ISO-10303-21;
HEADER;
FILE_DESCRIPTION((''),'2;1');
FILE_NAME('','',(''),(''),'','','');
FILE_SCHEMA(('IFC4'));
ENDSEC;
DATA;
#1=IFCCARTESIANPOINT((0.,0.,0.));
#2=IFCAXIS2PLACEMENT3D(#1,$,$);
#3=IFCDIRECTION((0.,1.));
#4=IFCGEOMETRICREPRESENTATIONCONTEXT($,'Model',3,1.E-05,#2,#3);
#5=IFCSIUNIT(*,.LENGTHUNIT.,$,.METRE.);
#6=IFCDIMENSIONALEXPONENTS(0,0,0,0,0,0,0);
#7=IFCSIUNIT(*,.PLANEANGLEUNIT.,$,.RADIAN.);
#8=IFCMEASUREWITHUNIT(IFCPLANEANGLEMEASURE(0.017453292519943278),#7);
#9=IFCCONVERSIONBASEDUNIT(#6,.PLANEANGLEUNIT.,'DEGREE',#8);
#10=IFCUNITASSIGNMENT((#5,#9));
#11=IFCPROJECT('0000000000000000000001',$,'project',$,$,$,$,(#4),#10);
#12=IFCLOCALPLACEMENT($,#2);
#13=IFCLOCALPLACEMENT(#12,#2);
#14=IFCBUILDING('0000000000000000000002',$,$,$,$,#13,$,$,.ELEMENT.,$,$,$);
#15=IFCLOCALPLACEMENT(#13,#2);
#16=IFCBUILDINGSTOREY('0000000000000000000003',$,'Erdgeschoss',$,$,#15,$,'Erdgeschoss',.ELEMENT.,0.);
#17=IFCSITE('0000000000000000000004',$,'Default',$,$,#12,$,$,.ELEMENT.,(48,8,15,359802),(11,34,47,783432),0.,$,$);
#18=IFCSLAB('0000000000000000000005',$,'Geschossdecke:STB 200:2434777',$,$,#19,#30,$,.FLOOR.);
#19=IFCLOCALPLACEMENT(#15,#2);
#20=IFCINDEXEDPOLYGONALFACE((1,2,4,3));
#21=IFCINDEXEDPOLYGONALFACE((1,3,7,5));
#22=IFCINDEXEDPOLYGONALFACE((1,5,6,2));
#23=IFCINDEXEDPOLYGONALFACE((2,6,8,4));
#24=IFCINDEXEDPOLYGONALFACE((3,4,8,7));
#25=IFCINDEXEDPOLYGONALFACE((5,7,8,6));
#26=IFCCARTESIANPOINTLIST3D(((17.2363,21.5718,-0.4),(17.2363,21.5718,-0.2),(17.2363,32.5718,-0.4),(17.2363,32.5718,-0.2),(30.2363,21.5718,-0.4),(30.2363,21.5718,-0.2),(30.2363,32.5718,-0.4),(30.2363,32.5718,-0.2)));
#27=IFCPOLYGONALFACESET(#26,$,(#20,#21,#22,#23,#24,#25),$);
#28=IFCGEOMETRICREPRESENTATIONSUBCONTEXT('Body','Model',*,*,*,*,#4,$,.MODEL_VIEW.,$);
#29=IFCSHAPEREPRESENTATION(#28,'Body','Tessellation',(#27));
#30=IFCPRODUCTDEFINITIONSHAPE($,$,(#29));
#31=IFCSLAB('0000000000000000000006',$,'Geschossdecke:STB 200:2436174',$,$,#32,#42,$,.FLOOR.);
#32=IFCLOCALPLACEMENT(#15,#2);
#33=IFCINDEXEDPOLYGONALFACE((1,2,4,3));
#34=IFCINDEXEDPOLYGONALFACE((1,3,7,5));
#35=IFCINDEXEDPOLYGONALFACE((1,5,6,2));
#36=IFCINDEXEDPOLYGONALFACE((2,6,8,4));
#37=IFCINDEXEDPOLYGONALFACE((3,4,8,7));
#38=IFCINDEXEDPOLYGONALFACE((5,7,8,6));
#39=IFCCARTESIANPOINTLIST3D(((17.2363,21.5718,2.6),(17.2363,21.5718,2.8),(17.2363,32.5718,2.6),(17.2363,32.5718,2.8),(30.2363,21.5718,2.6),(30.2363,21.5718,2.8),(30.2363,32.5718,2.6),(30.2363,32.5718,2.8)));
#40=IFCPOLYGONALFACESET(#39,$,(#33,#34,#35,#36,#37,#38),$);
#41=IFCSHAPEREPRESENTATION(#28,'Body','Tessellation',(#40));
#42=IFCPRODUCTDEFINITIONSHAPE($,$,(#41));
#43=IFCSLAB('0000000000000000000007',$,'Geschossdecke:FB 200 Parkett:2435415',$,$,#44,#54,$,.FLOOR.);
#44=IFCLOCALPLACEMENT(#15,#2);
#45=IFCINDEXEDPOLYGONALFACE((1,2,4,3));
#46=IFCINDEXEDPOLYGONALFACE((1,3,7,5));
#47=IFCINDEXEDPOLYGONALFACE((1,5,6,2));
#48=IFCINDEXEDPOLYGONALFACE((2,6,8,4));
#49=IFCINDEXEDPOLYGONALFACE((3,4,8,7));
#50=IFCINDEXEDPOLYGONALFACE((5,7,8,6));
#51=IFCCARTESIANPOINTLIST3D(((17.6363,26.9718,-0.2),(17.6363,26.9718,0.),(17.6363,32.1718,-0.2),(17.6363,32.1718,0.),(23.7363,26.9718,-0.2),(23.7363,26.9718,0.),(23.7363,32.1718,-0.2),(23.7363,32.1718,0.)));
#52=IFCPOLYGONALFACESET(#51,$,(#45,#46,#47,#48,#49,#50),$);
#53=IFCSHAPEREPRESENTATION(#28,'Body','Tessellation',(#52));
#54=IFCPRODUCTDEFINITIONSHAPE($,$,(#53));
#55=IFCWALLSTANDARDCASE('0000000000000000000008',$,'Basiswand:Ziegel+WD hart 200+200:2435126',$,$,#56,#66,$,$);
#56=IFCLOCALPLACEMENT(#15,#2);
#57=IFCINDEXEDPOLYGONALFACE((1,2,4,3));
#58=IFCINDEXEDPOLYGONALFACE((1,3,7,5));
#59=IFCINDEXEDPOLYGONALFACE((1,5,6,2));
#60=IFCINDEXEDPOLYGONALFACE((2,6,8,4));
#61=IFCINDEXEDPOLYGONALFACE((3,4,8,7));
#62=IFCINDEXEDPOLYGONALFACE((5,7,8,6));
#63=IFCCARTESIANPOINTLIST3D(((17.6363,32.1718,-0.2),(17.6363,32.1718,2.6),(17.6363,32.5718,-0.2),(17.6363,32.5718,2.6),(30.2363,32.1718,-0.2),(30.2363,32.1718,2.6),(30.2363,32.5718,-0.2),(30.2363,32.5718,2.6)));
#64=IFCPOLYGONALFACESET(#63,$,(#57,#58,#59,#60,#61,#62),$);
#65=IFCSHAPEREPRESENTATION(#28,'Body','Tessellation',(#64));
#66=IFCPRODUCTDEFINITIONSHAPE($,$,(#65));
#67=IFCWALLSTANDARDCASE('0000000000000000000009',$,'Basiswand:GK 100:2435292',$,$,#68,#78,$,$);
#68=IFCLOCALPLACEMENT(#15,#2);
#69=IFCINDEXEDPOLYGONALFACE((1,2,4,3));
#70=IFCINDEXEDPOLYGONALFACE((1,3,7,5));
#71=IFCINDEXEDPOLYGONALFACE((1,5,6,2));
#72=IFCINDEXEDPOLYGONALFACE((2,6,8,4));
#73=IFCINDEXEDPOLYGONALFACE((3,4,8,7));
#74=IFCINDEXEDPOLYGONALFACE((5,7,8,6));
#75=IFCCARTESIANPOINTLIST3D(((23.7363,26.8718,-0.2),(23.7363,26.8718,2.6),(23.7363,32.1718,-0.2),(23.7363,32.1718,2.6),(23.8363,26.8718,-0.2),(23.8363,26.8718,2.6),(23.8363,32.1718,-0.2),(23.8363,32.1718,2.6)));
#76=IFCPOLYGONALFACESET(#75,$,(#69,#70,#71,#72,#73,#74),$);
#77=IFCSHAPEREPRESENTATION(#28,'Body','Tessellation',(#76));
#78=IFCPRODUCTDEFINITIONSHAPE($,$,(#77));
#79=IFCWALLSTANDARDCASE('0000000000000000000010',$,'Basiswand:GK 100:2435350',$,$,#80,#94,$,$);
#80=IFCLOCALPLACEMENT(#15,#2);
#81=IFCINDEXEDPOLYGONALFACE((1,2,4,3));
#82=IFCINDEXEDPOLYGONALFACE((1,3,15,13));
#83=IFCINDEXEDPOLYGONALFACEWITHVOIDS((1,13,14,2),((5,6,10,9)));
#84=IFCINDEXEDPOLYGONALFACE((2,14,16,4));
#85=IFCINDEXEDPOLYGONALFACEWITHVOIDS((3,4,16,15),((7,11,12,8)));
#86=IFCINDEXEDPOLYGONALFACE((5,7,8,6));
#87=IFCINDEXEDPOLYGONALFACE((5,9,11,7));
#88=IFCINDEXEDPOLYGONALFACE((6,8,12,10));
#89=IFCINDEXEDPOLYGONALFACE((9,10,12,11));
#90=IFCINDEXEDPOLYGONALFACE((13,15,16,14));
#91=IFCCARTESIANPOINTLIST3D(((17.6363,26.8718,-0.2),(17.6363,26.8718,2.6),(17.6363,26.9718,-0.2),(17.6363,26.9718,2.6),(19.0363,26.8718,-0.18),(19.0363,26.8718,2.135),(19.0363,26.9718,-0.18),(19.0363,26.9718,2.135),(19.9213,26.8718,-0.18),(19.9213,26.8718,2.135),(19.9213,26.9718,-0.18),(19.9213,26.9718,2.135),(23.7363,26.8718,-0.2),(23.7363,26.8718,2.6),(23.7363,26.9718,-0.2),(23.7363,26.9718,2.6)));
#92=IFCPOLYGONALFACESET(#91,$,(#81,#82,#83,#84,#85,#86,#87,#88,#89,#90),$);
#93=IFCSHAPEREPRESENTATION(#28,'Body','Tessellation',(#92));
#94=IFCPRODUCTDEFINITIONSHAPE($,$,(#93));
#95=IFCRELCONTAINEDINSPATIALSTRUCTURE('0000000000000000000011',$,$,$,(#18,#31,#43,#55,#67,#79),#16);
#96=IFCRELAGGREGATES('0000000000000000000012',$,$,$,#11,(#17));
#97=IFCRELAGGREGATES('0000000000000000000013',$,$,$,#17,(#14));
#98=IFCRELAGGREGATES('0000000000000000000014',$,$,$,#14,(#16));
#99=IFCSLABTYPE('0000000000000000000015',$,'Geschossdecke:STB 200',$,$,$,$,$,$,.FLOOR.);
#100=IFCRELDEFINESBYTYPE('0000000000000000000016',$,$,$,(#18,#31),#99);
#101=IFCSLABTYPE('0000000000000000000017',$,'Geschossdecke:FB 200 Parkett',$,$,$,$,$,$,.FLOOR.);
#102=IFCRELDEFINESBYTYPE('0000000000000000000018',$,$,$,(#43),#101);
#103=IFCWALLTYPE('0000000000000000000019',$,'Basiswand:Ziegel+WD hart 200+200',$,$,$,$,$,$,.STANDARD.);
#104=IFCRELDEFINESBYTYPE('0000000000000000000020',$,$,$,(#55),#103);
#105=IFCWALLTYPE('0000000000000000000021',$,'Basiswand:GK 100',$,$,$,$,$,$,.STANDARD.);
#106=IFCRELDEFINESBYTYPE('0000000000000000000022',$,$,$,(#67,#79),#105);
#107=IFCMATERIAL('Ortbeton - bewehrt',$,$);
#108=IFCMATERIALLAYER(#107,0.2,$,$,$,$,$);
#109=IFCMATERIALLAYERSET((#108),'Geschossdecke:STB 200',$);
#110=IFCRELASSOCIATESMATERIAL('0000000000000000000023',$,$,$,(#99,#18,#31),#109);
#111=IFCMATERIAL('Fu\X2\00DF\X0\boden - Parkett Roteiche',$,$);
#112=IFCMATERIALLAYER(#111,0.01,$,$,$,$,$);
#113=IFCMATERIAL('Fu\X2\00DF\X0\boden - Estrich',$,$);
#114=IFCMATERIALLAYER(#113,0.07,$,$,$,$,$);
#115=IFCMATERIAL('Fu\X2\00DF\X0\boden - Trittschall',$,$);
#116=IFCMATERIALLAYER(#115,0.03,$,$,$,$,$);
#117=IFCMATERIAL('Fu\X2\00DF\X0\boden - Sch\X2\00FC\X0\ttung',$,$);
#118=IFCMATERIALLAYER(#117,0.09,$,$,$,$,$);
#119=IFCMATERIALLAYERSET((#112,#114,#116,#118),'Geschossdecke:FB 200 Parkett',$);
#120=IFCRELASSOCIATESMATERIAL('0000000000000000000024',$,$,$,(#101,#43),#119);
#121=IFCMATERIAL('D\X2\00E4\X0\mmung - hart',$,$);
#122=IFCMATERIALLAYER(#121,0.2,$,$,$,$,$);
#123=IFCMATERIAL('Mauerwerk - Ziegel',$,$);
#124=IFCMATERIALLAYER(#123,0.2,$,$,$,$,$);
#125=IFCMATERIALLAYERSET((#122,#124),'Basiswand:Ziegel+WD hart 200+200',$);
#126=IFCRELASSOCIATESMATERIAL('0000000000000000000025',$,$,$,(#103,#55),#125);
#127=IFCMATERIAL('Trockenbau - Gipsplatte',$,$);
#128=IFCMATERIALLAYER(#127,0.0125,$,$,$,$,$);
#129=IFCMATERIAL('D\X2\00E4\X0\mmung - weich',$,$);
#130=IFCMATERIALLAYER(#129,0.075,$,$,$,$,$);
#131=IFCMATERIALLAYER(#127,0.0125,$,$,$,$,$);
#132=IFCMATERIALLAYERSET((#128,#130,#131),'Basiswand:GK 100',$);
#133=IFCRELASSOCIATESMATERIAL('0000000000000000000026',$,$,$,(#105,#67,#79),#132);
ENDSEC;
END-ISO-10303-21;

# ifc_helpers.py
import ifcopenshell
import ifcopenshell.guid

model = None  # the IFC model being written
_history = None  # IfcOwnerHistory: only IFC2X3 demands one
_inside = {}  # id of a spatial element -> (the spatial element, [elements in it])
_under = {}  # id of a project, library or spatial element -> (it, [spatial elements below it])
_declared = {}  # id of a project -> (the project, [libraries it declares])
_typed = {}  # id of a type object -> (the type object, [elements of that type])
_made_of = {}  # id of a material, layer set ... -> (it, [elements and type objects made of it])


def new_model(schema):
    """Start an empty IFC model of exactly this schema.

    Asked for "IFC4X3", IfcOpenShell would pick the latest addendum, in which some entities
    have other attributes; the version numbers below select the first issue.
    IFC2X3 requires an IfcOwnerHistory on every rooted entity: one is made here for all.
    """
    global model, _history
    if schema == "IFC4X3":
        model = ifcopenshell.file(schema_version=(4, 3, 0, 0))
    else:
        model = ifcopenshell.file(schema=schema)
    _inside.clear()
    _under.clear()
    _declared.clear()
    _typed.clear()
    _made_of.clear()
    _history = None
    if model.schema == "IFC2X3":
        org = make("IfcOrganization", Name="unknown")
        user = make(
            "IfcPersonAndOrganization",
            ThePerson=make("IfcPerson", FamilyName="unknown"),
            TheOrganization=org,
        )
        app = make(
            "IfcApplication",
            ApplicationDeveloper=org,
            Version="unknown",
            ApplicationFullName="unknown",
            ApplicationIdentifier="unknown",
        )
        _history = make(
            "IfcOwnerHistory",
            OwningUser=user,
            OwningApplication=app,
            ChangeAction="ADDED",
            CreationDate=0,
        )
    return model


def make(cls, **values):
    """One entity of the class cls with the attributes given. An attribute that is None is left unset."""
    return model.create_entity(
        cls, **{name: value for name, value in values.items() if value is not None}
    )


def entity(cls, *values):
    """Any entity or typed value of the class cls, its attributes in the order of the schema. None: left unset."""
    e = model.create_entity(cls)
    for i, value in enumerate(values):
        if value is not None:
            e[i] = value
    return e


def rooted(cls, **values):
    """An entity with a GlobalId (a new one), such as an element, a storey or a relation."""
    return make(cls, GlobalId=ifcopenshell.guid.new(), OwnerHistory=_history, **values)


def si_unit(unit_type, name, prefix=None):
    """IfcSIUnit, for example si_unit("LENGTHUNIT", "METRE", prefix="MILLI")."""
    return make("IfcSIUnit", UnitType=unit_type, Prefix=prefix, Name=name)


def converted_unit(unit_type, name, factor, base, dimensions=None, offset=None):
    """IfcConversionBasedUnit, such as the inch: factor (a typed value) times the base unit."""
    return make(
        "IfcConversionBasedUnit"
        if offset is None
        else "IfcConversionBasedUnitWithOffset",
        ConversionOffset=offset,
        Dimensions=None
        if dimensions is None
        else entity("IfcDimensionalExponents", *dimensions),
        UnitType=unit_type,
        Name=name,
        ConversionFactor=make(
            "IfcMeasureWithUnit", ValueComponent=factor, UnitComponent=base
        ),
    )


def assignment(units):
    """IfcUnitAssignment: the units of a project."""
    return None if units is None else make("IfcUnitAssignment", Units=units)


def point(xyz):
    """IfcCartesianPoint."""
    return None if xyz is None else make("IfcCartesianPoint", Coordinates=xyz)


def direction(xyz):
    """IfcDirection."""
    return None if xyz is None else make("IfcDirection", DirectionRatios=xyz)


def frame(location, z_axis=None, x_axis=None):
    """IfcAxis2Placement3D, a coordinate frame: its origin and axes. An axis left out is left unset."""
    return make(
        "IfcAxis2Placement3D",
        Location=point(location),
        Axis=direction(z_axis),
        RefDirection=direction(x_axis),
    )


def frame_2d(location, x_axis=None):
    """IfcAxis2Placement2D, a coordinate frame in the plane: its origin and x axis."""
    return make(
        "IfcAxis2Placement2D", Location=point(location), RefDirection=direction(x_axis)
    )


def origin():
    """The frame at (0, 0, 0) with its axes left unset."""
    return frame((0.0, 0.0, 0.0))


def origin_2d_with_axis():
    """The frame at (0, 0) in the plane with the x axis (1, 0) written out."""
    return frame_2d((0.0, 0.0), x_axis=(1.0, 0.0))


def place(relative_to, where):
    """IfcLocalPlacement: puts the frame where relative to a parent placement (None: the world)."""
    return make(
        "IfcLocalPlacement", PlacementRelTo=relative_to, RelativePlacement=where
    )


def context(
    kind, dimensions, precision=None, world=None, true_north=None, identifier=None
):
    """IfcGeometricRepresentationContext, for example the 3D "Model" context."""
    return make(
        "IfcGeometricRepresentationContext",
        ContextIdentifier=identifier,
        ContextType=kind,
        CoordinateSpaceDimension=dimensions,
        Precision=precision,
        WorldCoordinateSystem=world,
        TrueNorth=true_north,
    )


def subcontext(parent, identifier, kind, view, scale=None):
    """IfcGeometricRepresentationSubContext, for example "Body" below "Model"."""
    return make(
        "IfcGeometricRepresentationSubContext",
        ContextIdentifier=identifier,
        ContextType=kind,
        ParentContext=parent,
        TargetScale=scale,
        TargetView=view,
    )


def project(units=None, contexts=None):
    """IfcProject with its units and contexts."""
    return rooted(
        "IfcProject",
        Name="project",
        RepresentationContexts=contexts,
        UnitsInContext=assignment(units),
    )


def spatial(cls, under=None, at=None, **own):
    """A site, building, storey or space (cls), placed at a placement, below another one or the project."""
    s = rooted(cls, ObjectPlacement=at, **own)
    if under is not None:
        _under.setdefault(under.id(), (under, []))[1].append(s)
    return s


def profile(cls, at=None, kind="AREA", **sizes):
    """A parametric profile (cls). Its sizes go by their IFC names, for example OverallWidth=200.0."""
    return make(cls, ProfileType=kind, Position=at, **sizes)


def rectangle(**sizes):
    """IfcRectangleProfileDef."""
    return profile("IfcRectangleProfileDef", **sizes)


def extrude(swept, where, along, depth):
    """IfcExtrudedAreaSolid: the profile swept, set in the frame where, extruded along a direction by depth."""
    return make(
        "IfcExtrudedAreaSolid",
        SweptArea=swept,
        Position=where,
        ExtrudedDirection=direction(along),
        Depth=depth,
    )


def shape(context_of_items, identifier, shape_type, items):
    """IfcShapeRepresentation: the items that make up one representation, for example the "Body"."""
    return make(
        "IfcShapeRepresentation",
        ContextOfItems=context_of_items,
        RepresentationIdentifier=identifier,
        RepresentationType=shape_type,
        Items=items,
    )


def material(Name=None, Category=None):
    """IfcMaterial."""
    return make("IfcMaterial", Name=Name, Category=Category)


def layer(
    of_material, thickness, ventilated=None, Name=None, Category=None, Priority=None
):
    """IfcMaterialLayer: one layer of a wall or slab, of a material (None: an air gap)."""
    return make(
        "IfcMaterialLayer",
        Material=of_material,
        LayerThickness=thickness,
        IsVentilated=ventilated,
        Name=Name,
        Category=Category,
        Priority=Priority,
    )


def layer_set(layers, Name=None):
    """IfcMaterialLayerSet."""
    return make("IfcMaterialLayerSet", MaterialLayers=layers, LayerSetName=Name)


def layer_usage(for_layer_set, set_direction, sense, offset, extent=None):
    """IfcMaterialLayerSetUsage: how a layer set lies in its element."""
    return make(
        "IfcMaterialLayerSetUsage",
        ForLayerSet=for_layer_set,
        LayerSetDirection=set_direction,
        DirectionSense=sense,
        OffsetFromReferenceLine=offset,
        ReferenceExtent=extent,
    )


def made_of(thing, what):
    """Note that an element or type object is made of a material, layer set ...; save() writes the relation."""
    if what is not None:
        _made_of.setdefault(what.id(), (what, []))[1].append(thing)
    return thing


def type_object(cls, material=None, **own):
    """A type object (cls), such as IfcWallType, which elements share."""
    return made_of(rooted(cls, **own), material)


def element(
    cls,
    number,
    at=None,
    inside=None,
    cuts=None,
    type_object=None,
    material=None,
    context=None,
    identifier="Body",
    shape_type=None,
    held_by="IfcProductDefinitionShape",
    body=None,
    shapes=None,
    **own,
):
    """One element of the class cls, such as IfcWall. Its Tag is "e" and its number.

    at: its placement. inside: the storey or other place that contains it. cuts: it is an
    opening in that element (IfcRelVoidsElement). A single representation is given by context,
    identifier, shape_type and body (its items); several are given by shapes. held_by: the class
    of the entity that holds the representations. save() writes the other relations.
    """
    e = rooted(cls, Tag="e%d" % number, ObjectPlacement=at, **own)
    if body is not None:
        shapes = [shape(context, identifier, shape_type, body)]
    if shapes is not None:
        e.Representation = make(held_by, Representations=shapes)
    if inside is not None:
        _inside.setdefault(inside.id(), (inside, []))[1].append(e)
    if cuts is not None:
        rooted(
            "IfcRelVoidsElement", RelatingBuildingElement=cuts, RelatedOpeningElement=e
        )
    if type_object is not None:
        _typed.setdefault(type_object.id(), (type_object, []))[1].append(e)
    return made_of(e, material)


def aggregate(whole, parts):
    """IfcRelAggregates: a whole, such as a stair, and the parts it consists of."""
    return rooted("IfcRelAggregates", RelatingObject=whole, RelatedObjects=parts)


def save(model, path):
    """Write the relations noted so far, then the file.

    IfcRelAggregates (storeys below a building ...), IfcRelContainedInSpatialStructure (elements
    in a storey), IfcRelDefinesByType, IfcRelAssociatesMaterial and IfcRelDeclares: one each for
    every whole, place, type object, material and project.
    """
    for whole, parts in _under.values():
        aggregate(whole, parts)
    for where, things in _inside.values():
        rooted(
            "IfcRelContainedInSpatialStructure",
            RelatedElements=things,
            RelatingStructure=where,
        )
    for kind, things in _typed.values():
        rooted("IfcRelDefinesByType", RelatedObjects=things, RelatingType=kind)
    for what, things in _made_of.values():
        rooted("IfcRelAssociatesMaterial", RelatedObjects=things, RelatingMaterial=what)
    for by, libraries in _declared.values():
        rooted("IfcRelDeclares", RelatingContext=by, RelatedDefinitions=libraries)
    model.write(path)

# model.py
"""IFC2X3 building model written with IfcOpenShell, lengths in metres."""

from ifc_helpers import new_model, entity, si_unit, converted_unit, direction, frame, frame_2d, origin, origin_2d_with_axis, place, context, subcontext, project, spatial, rectangle, extrude, material, layer, layer_set, layer_usage, type_object, element, save


model = new_model("IFC2X3")

# Units and contexts
model_context = context("Model", 3, precision=1e-05, world=origin(), true_north=direction((0.0, 1.0)))
body_context = subcontext(model_context, "Body", "Model", "MODEL_VIEW")
ifc_project = project(units=[si_unit("LENGTHUNIT", "METRE"), converted_unit("PLANEANGLEUNIT", "DEGREE", entity("IfcPlaneAngleMeasure", 0.017453292519943278), si_unit("PLANEANGLEUNIT", "RADIAN"), dimensions=[0, 0, 0, 0, 0, 0, 0])], contexts=[model_context])

# Site, building, storey
site_placement = place(None, origin())
site = spatial("IfcSite", under=ifc_project, at=site_placement, Name="Default", CompositionType="ELEMENT", RefLatitude=(48, 8, 15, 359802), RefLongitude=(11, 34, 47, 783432), RefElevation=0.0)
building_placement = place(site_placement, origin())
building = spatial("IfcBuilding", under=site, at=building_placement, CompositionType="ELEMENT")
storey_placement = place(building_placement, origin())
storey = spatial("IfcBuildingStorey", under=building, at=storey_placement, Name="Erdgeschoss", LongName="Erdgeschoss", CompositionType="ELEMENT", Elevation=0.0)

# Slabs
ifc_material_1 = material(Name="Ortbeton - bewehrt")
ifc_layer_1 = layer(ifc_material_1, 0.2)
ifc_layer_set_1 = layer_set([ifc_layer_1], Name="Geschossdecke:STB 200")
ifc_layer_usage_1 = layer_usage(ifc_layer_set_1, "AXIS3", "POSITIVE", 0.0)
slab_type_1 = type_object("IfcSlabType", Name="Geschossdecke:STB 200", PredefinedType="FLOOR", material=ifc_layer_set_1)
slab_1_placement = place(storey_placement, origin())
element("IfcSlab", 1, at=slab_1_placement, inside=storey, type_object=slab_type_1, material=ifc_layer_usage_1, Name="Geschossdecke:STB 200:2434777", PredefinedType="FLOOR", context=body_context, shape_type="SweptSolid", body=[
    extrude(rectangle(XDim=11.0, YDim=13.0, at=origin_2d_with_axis()), frame((23.7363, 27.0718, -0.2), z_axis=(0.0, 0.0, -1.0), x_axis=(0.0, 1.0, 0.0)), (0.0, 0.0, 1.0), 0.2),
])
ifc_layer_usage_2 = layer_usage(ifc_layer_set_1, "AXIS3", "POSITIVE", 0.0)
slab_2_placement = place(storey_placement, origin())
element("IfcSlab", 2, at=slab_2_placement, inside=storey, type_object=slab_type_1, material=ifc_layer_usage_2, Name="Geschossdecke:STB 200:2436174", PredefinedType="FLOOR", context=body_context, shape_type="SweptSolid", body=[
    extrude(rectangle(XDim=11.0, YDim=13.0, at=origin_2d_with_axis()), frame((23.7363, 27.0718, 2.8), z_axis=(0.0, 0.0, -1.0), x_axis=(0.0, 1.0, 0.0)), (0.0, 0.0, 1.0), 0.2),
])
ifc_material_2 = material(Name="Fußboden - Parkett Roteiche")
ifc_layer_2 = layer(ifc_material_2, 0.01)
ifc_material_3 = material(Name="Fußboden - Estrich")
ifc_layer_3 = layer(ifc_material_3, 0.07)
ifc_material_4 = material(Name="Fußboden - Trittschall")
ifc_layer_4 = layer(ifc_material_4, 0.03)
ifc_material_5 = material(Name="Fußboden - Schüttung")
ifc_layer_5 = layer(ifc_material_5, 0.09)
ifc_layer_set_2 = layer_set([ifc_layer_2, ifc_layer_3, ifc_layer_4, ifc_layer_5], Name="Geschossdecke:FB 200 Parkett")
ifc_layer_usage_3 = layer_usage(ifc_layer_set_2, "AXIS3", "POSITIVE", 0.0)
slab_type_2 = type_object("IfcSlabType", Name="Geschossdecke:FB 200 Parkett", PredefinedType="FLOOR", material=ifc_layer_set_2)
slab_3_placement = place(storey_placement, origin())
element("IfcSlab", 3, at=slab_3_placement, inside=storey, type_object=slab_type_2, material=ifc_layer_usage_3, Name="Geschossdecke:FB 200 Parkett:2435415", PredefinedType="FLOOR", context=body_context, shape_type="SweptSolid", body=[
    extrude(rectangle(XDim=5.2, YDim=6.1, at=frame_2d((0.0, 0.0), x_axis=(1.0, 0.0))), frame((20.6863, 29.5718, 0.0), z_axis=(0.0, 0.0, -1.0), x_axis=(0.0, 1.0, 0.0)), (0.0, 0.0, 1.0), 0.2),
])

# Walls
ifc_material_6 = material(Name="Dämmung - hart")
ifc_layer_6 = layer(ifc_material_6, 0.2)
ifc_material_7 = material(Name="Mauerwerk - Ziegel")
ifc_layer_7 = layer(ifc_material_7, 0.2)
ifc_layer_set_3 = layer_set([ifc_layer_6, ifc_layer_7], Name="Basiswand:Ziegel+WD hart 200+200")
ifc_layer_usage_4 = layer_usage(ifc_layer_set_3, "AXIS2", "NEGATIVE", 0.2)
wall_type_1 = type_object("IfcWallType", Name="Basiswand:Ziegel+WD hart 200+200", PredefinedType="STANDARD", material=ifc_layer_set_3)
wall_1_placement = place(storey_placement, frame((17.6363, 32.3718, -0.2)))
element("IfcWallStandardCase", 4, at=wall_1_placement, inside=storey, type_object=wall_type_1, material=ifc_layer_usage_4, Name="Basiswand:Ziegel+WD hart 200+200:2435126", context=body_context, shape_type="SweptSolid", body=[
    extrude(rectangle(XDim=12.6, YDim=0.4, at=frame_2d((6.3, 0.0), x_axis=(-1.0, 0.0))), origin(), (0.0, 0.0, 1.0), 2.8),
])
ifc_material_8 = material(Name="Trockenbau - Gipsplatte")
ifc_layer_8 = layer(ifc_material_8, 0.0125)
ifc_material_9 = material(Name="Dämmung - weich")
ifc_layer_9 = layer(ifc_material_9, 0.075)
ifc_layer_10 = layer(ifc_material_8, 0.0125)
ifc_layer_set_4 = layer_set([ifc_layer_8, ifc_layer_9, ifc_layer_10], Name="Basiswand:GK 100")
ifc_layer_usage_5 = layer_usage(ifc_layer_set_4, "AXIS2", "NEGATIVE", 0.05)
wall_type_2 = type_object("IfcWallType", Name="Basiswand:GK 100", PredefinedType="STANDARD", material=ifc_layer_set_4)
wall_2_placement = place(storey_placement, frame((23.7863, 32.1718, -0.2), z_axis=(0.0, 0.0, 1.0), x_axis=(0.0, -1.0, 0.0)))
element("IfcWallStandardCase", 5, at=wall_2_placement, inside=storey, type_object=wall_type_2, material=ifc_layer_usage_5, Name="Basiswand:GK 100:2435292", context=body_context, shape_type="SweptSolid", body=[
    extrude(rectangle(XDim=5.3, YDim=0.1, at=frame_2d((2.65, 0.0), x_axis=(-1.0, 0.0))), origin(), (0.0, 0.0, 1.0), 2.8),
])

# Wall, opening
ifc_layer_usage_6 = layer_usage(ifc_layer_set_4, "AXIS2", "NEGATIVE", 0.05)
wall_3_placement = place(storey_placement, frame((23.7363, 26.9218, -0.2), z_axis=(0.0, 0.0, 1.0), x_axis=(-1.0, 0.0, 0.0)))
wall_3 = element("IfcWallStandardCase", 6, at=wall_3_placement, inside=storey, type_object=wall_type_2, material=ifc_layer_usage_6, Name="Basiswand:GK 100:2435350", context=body_context, shape_type="SweptSolid", body=[
    extrude(rectangle(XDim=6.1, YDim=0.1, at=frame_2d((3.05, 0.0), x_axis=(-1.0, 0.0))), origin(), (0.0, 0.0, 1.0), 2.8),
])
opening_placement = place(wall_3_placement, frame((3.815, -0.05, 0.02)))
element("IfcOpeningElement", 7, at=opening_placement, cuts=wall_3, ObjectType="Opening", context=body_context, shape_type="SweptSolid", body=[
    extrude(rectangle(XDim=2.315, YDim=0.885, at=frame_2d((1.1575, 0.4425), x_axis=(-1.0, 0.0))), frame((0.0, 0.0, 0.0), z_axis=(0.0, 1.0, 0.0), x_axis=(0.0, 0.0, 1.0)), (0.0, 0.0, 1.0), 0.1),
])

save(model, "model.ifc")
